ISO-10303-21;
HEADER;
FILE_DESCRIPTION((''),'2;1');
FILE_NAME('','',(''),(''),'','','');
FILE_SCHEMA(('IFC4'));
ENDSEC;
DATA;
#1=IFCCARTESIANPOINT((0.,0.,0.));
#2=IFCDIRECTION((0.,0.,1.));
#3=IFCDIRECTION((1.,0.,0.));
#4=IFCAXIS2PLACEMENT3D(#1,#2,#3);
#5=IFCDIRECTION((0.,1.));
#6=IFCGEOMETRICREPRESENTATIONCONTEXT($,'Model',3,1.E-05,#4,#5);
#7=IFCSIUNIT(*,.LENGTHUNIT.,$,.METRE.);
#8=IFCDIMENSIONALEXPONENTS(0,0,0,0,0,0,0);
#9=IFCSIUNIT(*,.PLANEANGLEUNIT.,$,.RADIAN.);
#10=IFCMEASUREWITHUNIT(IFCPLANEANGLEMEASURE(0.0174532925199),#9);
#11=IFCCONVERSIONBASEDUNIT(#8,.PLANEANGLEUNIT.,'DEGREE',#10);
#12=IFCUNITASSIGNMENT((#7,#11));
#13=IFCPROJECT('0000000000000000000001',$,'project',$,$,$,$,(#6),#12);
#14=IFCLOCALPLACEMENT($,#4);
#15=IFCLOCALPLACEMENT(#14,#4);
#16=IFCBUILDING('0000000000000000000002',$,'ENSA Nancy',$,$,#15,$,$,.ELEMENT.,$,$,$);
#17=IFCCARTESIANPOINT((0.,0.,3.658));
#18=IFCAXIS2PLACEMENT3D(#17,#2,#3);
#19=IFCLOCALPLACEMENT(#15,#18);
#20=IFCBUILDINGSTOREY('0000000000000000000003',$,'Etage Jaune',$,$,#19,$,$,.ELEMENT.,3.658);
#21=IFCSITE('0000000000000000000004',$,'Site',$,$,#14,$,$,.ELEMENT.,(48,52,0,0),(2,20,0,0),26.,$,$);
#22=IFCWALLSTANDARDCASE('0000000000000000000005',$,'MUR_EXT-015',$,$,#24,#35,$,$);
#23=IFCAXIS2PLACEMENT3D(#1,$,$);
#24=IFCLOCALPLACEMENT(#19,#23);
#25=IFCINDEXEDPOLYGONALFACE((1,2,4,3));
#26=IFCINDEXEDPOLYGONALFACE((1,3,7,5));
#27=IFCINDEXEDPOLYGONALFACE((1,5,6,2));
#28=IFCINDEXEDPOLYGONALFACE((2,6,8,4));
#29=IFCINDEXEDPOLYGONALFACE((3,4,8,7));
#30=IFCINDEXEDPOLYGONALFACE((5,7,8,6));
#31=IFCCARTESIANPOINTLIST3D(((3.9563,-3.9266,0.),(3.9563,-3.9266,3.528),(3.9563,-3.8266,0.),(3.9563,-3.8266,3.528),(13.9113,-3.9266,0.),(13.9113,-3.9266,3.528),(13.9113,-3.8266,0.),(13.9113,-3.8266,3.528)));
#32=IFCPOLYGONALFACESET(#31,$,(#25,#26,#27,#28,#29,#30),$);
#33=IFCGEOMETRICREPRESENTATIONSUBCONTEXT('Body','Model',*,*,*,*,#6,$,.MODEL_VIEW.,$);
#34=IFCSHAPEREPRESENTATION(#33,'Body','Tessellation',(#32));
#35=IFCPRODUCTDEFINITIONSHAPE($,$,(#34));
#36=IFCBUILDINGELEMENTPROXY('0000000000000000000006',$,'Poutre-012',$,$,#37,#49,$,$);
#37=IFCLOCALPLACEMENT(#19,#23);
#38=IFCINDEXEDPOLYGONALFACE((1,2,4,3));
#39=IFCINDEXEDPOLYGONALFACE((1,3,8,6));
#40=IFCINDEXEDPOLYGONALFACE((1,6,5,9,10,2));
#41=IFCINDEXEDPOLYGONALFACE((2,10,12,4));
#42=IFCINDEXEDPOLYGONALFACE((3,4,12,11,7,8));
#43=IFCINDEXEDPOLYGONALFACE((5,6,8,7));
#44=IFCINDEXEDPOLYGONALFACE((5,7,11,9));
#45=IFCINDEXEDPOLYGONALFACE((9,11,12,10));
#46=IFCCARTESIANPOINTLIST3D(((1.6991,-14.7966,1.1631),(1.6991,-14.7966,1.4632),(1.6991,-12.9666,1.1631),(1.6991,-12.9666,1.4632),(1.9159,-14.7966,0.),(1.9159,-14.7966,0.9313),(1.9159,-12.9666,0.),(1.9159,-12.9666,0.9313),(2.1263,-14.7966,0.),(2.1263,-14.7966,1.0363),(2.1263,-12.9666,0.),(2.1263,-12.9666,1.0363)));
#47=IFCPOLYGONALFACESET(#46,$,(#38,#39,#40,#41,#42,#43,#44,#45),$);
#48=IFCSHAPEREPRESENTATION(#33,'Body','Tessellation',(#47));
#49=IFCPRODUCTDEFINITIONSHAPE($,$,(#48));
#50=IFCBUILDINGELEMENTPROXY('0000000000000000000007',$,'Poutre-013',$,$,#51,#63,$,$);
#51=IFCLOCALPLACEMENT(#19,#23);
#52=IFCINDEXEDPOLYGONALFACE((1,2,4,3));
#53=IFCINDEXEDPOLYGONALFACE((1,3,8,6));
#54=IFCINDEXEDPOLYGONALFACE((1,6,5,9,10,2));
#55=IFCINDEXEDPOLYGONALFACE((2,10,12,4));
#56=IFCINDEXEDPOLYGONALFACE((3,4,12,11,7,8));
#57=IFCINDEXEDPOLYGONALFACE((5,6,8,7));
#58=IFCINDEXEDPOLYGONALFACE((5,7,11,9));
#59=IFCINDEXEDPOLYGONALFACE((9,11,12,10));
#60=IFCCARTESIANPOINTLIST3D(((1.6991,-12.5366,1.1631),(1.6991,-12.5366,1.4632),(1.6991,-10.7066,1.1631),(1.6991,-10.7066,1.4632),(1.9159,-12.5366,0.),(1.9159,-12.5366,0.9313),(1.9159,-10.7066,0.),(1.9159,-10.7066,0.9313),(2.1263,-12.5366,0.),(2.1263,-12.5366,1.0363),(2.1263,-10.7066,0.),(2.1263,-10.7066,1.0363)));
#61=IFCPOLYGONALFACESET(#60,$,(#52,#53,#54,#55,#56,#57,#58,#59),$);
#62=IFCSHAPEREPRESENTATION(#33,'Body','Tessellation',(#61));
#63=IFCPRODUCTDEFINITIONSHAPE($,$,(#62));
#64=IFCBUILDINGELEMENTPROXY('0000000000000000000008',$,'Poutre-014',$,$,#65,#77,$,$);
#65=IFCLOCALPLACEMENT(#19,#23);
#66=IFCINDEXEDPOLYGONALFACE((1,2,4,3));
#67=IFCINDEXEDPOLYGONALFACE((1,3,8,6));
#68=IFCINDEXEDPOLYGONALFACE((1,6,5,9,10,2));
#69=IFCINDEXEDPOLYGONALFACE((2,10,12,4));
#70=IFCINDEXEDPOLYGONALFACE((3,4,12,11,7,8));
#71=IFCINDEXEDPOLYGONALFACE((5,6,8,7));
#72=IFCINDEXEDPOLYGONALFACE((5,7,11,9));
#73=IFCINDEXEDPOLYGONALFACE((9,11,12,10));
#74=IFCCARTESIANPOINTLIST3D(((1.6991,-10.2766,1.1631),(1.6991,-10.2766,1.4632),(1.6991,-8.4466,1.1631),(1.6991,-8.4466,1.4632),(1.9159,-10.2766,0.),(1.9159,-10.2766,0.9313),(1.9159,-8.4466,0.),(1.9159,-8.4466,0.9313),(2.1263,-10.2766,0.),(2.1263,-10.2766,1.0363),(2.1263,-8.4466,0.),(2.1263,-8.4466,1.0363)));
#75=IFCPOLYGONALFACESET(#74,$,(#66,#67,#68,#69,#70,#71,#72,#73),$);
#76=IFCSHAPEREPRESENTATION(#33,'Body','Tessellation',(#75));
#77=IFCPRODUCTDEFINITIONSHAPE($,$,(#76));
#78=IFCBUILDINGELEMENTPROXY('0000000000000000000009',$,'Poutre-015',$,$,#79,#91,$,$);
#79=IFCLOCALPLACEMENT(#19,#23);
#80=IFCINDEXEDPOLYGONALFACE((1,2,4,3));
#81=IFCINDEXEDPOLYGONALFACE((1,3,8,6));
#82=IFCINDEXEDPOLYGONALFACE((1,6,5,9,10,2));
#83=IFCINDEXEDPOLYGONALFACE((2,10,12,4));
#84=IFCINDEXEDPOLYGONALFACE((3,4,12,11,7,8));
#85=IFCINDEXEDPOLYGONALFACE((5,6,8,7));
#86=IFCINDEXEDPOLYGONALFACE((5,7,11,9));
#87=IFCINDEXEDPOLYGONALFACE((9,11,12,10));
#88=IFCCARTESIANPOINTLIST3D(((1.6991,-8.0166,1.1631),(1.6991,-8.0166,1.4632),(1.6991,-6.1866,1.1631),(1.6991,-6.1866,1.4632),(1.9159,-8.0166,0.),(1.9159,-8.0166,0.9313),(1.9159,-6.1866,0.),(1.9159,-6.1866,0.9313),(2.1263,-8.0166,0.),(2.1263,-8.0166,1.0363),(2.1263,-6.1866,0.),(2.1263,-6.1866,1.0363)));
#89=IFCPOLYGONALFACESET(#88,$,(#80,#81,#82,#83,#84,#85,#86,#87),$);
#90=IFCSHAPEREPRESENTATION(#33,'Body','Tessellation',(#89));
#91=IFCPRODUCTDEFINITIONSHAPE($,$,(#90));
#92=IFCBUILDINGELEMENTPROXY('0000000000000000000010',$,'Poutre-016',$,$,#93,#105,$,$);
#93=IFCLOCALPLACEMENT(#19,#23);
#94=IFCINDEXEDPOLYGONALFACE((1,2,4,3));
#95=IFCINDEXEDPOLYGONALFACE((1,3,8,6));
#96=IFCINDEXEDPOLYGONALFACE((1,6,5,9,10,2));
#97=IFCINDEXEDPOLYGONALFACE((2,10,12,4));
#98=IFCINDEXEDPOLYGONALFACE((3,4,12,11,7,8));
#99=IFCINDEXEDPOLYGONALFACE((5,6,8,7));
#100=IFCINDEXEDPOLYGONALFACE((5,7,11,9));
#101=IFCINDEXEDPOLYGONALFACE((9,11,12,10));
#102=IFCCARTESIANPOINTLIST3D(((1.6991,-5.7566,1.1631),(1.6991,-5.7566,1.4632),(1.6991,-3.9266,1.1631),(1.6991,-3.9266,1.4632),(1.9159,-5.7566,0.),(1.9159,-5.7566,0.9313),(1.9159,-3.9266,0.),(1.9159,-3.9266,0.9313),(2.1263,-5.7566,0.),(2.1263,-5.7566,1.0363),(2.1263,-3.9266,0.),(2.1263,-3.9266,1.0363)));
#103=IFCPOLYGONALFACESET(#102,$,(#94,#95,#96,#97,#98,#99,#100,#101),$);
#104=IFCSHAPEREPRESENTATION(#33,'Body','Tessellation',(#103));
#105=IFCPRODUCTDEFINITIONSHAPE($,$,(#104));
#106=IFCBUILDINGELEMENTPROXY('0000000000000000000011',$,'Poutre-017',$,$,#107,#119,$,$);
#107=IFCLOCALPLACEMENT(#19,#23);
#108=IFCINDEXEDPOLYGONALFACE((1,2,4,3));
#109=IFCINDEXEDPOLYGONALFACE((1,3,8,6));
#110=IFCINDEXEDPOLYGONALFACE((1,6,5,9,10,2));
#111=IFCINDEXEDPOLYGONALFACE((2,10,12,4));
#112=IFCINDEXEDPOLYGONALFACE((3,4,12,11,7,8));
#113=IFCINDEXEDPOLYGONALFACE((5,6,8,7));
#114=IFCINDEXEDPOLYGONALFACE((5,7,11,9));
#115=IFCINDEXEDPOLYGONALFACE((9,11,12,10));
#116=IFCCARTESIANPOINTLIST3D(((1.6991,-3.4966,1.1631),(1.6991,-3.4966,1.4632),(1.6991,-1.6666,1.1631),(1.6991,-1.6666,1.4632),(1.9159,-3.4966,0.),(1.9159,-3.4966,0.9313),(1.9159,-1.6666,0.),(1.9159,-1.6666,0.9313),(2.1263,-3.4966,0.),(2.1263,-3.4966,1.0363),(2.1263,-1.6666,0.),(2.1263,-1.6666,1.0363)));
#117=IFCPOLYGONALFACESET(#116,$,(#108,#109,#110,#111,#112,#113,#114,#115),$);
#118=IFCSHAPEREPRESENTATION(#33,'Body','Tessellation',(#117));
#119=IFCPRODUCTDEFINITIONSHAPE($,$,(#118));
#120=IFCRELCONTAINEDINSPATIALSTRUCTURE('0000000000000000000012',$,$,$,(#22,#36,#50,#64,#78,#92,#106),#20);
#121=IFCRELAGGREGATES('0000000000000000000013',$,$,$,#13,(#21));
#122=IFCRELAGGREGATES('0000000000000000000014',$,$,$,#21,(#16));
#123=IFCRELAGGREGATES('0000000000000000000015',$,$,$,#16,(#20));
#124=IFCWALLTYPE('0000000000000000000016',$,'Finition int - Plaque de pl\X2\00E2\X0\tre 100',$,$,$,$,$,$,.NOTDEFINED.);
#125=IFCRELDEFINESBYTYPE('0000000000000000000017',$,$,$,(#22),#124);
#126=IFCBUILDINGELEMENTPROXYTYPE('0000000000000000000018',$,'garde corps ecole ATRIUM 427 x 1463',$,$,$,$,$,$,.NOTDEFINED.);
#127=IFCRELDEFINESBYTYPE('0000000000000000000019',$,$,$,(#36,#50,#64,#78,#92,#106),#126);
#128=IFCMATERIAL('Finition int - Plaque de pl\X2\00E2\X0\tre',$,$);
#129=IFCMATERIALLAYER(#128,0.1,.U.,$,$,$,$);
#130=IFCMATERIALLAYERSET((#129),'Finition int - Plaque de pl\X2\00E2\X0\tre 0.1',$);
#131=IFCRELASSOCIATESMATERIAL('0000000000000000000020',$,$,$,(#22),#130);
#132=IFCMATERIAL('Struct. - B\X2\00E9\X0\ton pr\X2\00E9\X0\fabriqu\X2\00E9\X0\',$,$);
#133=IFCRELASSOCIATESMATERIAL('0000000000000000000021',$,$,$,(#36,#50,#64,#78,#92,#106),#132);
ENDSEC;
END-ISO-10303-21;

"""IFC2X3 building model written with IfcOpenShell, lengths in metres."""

from ifc_helpers import new_model, entity, si_unit, converted_unit, direction, frame, origin_with_axes, place, context, subcontext, project, spatial, polyline, outline, extrude, material, layer, layer_set, layer_usage, type_object, element, save


model = new_model("IFC2X3")

# Units and contexts
model_context = context("Model", 3, precision=1e-05, world=origin_with_axes(), true_north=direction((0.0, 1.0)))
body_context = subcontext(model_context, "Body", "Model", "MODEL_VIEW")
ifc_project = project(units=[si_unit("LENGTHUNIT", "METRE"), converted_unit("PLANEANGLEUNIT", "DEGREE", entity("IfcPlaneAngleMeasure", 0.0174532925199), si_unit("PLANEANGLEUNIT", "RADIAN"), dimensions=[0, 0, 0, 0, 0, 0, 0])], contexts=[model_context])

# Site, building, storey
site_placement = place(None, origin_with_axes())
site = spatial("IfcSite", under=ifc_project, at=site_placement, Name="Site", CompositionType="ELEMENT", RefLatitude=(48, 52, 0, 0), RefLongitude=(2, 20, 0, 0), RefElevation=26.0)
building_placement = place(site_placement, origin_with_axes())
building = spatial("IfcBuilding", under=site, at=building_placement, Name="ENSA Nancy", CompositionType="ELEMENT")
storey_placement = place(building_placement, frame((0.0, 0.0, 3.658), z_axis=(0.0, 0.0, 1.0), x_axis=(1.0, 0.0, 0.0)))
storey = spatial("IfcBuildingStorey", under=building, at=storey_placement, Name="Etage Jaune", CompositionType="ELEMENT", Elevation=3.658)

# Wall
ifc_material_1 = material(Name="Finition int - Plaque de plâtre")
ifc_layer = layer(ifc_material_1, 0.1, ventilated="UNKNOWN")
ifc_layer_set = layer_set([ifc_layer], Name="Finition int - Plaque de plâtre 0.1")
ifc_layer_usage = layer_usage(ifc_layer_set, "AXIS2", "NEGATIVE", 0.1)
wall_type = type_object("IfcWallType", Name="Finition int - Plaque de plâtre 100", PredefinedType="NOTDEFINED")
wall_placement = place(storey_placement, frame((3.9563, -3.9266, 0.0), z_axis=(0.0, 0.0, 1.0), x_axis=(1.0, 0.0, 0.0)))
element("IfcWallStandardCase", 1, at=wall_placement, inside=storey, type_object=wall_type, material=ifc_layer_usage, Name="MUR_EXT-015", context=body_context, shape_type="SweptSolid", body=[
    extrude(outline(polyline([(0.0, 0.0), (9.955, 0.0), (9.955, 0.1), (0.0, 0.1), (0.0, 0.0)])), origin_with_axes(), (0.0, 0.0, 1.0), 3.528),
])

# Building element proxies
ifc_material_2 = material(Name="Struct. - Béton préfabriqué")
building_element_proxy_type_1 = type_object("IfcBuildingElementProxyType", Name="garde corps ecole ATRIUM 427 x 1463", PredefinedType="NOTDEFINED")
proxy_1_placement = place(storey_placement, frame((2.1263, -14.7966, 0.0), z_axis=(0.0, 0.0, 1.0), x_axis=(1.0, 0.0, 0.0)))
element("IfcBuildingElementProxy", 2, at=proxy_1_placement, inside=storey, type_object=building_element_proxy_type_1, material=ifc_material_2, Name="Poutre-012", context=body_context, shape_type="SweptSolid", body=[
    extrude(outline(polyline([(0.0, 1.0363), (0.0, 0.0), (0.2105, 0.0), (0.2105, 0.9313), (0.4272, 1.1631), (0.4272, 1.4632), (0.0, 1.0363)])), frame((0.0, 1.83, 0.0), z_axis=(0.0, 1.0, 0.0), x_axis=(-1.0, 0.0, 0.0)), (0.0, 0.0, -1.0), 1.83),
])
proxy_2_placement = place(storey_placement, frame((2.1263, -12.5366, 0.0), z_axis=(0.0, 0.0, 1.0), x_axis=(1.0, 0.0, 0.0)))
element("IfcBuildingElementProxy", 3, at=proxy_2_placement, inside=storey, type_object=building_element_proxy_type_1, material=ifc_material_2, Name="Poutre-013", context=body_context, shape_type="SweptSolid", body=[
    extrude(outline(polyline([(0.0, 1.0363), (0.0, 0.0), (0.2105, 0.0), (0.2105, 0.9313), (0.4272, 1.1631), (0.4272, 1.4632), (0.0, 1.0363)])), frame((0.0, 1.83, 0.0), z_axis=(0.0, 1.0, 0.0), x_axis=(-1.0, 0.0, 0.0)), (0.0, 0.0, -1.0), 1.83),
])
proxy_3_placement = place(storey_placement, frame((2.1263, -10.2766, 0.0), z_axis=(0.0, 0.0, 1.0), x_axis=(1.0, 0.0, 0.0)))
element("IfcBuildingElementProxy", 4, at=proxy_3_placement, inside=storey, type_object=building_element_proxy_type_1, material=ifc_material_2, Name="Poutre-014", context=body_context, shape_type="SweptSolid", body=[
    extrude(outline(polyline([(0.0, 1.0363), (0.0, 0.0), (0.2105, 0.0), (0.2105, 0.9313), (0.4272, 1.1631), (0.4272, 1.4632), (0.0, 1.0363)])), frame((0.0, 1.83, 0.0), z_axis=(0.0, 1.0, 0.0), x_axis=(-1.0, 0.0, 0.0)), (0.0, 0.0, -1.0), 1.83),
])
proxy_4_placement = place(storey_placement, frame((2.1263, -8.0166, 0.0), z_axis=(0.0, 0.0, 1.0), x_axis=(1.0, 0.0, 0.0)))
element("IfcBuildingElementProxy", 5, at=proxy_4_placement, inside=storey, type_object=building_element_proxy_type_1, material=ifc_material_2, Name="Poutre-015", context=body_context, shape_type="SweptSolid", body=[
    extrude(outline(polyline([(0.0, 1.0363), (0.0, 0.0), (0.2105, 0.0), (0.2105, 0.9313), (0.4272, 1.1631), (0.4272, 1.4632), (0.0, 1.0363)])), frame((0.0, 1.83, 0.0), z_axis=(0.0, 1.0, 0.0), x_axis=(-1.0, 0.0, 0.0)), (0.0, 0.0, -1.0), 1.83),
])
proxy_5_placement = place(storey_placement, frame((2.1263, -5.7566, 0.0), z_axis=(0.0, 0.0, 1.0), x_axis=(1.0, 0.0, 0.0)))
element("IfcBuildingElementProxy", 6, at=proxy_5_placement, inside=storey, type_object=building_element_proxy_type_1, material=ifc_material_2, Name="Poutre-016", context=body_context, shape_type="SweptSolid", body=[
    extrude(outline(polyline([(0.0, 1.0363), (0.0, 0.0), (0.2105, 0.0), (0.2105, 0.9313), (0.4272, 1.1631), (0.4272, 1.4632), (0.0, 1.0363)])), frame((0.0, 1.83, 0.0), z_axis=(0.0, 1.0, 0.0), x_axis=(-1.0, 0.0, 0.0)), (0.0, 0.0, -1.0), 1.83),
])
proxy_6_placement = place(storey_placement, frame((2.1263, -3.4966, 0.0), z_axis=(0.0, 0.0, 1.0), x_axis=(1.0, 0.0, 0.0)))
element("IfcBuildingElementProxy", 7, at=proxy_6_placement, inside=storey, type_object=building_element_proxy_type_1, material=ifc_material_2, Name="Poutre-017", context=body_context, shape_type="SweptSolid", body=[
    extrude(outline(polyline([(0.0, 1.0363), (0.0, 0.0), (0.2105, 0.0), (0.2105, 0.9313), (0.4272, 1.1631), (0.4272, 1.4632), (0.0, 1.0363)])), frame((0.0, 1.83, 0.0), z_axis=(0.0, 1.0, 0.0), x_axis=(-1.0, 0.0, 0.0)), (0.0, 0.0, -1.0), 1.83),
])

save(model, "model.ifc")
